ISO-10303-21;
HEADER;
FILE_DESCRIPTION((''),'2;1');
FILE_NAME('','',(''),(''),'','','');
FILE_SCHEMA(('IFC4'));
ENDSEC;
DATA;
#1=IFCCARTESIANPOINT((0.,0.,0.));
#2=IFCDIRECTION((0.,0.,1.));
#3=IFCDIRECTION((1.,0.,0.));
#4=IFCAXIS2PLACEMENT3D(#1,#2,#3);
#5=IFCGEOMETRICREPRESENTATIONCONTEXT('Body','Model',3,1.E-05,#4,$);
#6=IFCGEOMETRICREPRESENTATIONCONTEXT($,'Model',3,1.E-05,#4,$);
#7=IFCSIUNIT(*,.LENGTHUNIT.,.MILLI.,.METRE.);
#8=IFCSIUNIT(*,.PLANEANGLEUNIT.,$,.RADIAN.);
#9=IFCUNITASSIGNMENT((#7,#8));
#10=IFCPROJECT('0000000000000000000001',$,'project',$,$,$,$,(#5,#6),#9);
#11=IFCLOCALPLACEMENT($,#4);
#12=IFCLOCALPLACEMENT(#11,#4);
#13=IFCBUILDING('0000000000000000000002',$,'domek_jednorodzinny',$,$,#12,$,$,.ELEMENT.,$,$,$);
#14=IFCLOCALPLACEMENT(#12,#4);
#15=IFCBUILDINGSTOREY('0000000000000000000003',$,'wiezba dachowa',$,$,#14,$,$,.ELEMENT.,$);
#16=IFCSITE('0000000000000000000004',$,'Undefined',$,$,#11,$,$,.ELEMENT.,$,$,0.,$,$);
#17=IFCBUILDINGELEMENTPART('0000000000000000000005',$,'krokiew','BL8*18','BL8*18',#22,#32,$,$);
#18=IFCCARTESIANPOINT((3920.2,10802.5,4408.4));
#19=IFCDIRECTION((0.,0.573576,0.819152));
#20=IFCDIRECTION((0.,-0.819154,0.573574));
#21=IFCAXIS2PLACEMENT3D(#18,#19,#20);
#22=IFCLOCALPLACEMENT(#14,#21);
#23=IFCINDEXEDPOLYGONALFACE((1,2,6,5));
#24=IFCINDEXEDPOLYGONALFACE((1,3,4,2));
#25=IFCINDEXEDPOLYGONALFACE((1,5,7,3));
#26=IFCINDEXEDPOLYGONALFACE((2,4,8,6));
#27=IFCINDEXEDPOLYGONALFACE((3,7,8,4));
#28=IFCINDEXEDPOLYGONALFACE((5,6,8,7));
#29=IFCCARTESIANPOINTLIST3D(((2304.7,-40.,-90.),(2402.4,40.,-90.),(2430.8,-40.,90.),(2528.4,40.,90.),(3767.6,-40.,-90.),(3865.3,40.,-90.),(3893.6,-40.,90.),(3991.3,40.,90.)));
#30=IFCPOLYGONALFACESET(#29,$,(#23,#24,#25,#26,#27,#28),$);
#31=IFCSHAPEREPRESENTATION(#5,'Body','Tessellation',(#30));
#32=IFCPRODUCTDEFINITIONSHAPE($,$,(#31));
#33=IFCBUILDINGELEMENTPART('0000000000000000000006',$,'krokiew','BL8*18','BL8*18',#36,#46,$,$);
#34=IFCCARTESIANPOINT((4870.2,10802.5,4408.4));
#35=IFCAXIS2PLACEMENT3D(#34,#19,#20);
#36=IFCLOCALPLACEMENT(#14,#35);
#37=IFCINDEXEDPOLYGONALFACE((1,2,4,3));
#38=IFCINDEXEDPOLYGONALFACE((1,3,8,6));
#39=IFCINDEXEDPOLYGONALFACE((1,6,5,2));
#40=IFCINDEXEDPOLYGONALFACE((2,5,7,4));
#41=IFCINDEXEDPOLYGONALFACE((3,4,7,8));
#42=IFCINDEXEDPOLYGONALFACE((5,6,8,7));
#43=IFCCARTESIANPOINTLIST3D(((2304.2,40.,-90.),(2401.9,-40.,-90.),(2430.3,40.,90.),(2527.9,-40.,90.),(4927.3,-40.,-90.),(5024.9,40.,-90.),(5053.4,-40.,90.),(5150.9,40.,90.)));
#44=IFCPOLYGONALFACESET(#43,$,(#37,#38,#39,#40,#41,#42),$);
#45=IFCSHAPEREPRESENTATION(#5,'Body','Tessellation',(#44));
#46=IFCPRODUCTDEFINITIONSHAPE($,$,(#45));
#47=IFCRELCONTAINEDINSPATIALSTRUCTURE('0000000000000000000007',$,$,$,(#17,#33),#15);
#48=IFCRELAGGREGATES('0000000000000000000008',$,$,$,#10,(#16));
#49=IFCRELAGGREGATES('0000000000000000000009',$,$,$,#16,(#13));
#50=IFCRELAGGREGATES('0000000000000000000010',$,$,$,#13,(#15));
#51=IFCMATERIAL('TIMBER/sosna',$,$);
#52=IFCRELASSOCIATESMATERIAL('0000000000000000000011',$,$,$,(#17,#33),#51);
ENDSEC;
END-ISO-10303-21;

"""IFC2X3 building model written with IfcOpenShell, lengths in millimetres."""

from ifc_helpers import new_model, si_unit, frame, origin_with_axes, origin_2d_with_axis, place, context, project, spatial, rectangle, extrude, clip, halfspace, material, element, save


model = new_model("IFC2X3")

# Units and contexts
model_context_1 = context("Model", 3, precision=1e-05, world=origin_with_axes(), identifier="Body")
model_context_2 = context("Model", 3, precision=1e-05, world=origin_with_axes())
ifc_project = project(units=[si_unit("LENGTHUNIT", "METRE", prefix="MILLI"), si_unit("PLANEANGLEUNIT", "RADIAN")], contexts=[model_context_1, model_context_2])

# Site, building, storey
site_placement = place(None, origin_with_axes())
site = spatial("IfcSite", under=ifc_project, at=site_placement, Name="Undefined", CompositionType="ELEMENT", RefElevation=0.0)
building_placement = place(site_placement, origin_with_axes())
building = spatial("IfcBuilding", under=site, at=building_placement, Name="domek_jednorodzinny", CompositionType="ELEMENT")
storey_placement = place(building_placement, origin_with_axes())
storey = spatial("IfcBuildingStorey", under=building, at=storey_placement, Name="wiezba dachowa", CompositionType="ELEMENT")

# Building element parts
ifc_material = material(Name="TIMBER/sosna")
building_element_part_1_placement = place(storey_placement, frame((3920.2, 10802.5, 4408.4), z_axis=(0.0, 0.573576, 0.819152), x_axis=(0.0, -0.819154, 0.573574)))
element("IfcBuildingElementPart", 1, at=building_element_part_1_placement, inside=storey, material=ifc_material, Name="krokiew", Description="BL8*18", ObjectType="BL8*18", context=model_context_1, shape_type="Clipping", body=[
    clip(clip(extrude(rectangle(XDim=80.0, YDim=180.0, at=origin_2d_with_axis()), frame((5727.3, 0.0, 0.0), z_axis=(-1.0, 0.0, 0.0), x_axis=(0.0, -1.0, 0.0)), (0.0, 0.0, 1.0), 5727.3), halfspace(frame((2304.7, -40.0, -90.0), z_axis=(-0.57923, 0.707106, 0.405578), x_axis=(0.773588, 0.633689, 0.0)), False)), halfspace(frame((3865.3, 40.0, -90.0), z_axis=(0.579228, -0.707106, -0.40558), x_axis=(-0.77359, -0.633686, 0.0)), False)),
])
building_element_part_2_placement = place(storey_placement, frame((4870.2, 10802.5, 4408.4), z_axis=(0.0, 0.573576, 0.819152), x_axis=(0.0, -0.819154, 0.573574)))
element("IfcBuildingElementPart", 2, at=building_element_part_2_placement, inside=storey, material=ifc_material, Name="krokiew", Description="BL8*18", ObjectType="BL8*18", context=model_context_1, shape_type="Clipping", body=[
    clip(clip(extrude(rectangle(XDim=80.0, YDim=180.0, at=origin_2d_with_axis()), frame((5727.3, 0.0, 0.0), z_axis=(-1.0, 0.0, 0.0), x_axis=(0.0, -1.0, 0.0)), (0.0, 0.0, 1.0), 5727.3), halfspace(frame((2401.9, -40.0, -90.0), z_axis=(-0.579227, -0.707107, 0.405581), x_axis=(-0.77359, 0.633686, 0.0)), False)), halfspace(frame((5024.9, 40.0, -90.0), z_axis=(0.579502, -0.706773, -0.405769), x_axis=(-0.773296, -0.634046, 0.0)), False)),
])

save(model, "model.ifc")
